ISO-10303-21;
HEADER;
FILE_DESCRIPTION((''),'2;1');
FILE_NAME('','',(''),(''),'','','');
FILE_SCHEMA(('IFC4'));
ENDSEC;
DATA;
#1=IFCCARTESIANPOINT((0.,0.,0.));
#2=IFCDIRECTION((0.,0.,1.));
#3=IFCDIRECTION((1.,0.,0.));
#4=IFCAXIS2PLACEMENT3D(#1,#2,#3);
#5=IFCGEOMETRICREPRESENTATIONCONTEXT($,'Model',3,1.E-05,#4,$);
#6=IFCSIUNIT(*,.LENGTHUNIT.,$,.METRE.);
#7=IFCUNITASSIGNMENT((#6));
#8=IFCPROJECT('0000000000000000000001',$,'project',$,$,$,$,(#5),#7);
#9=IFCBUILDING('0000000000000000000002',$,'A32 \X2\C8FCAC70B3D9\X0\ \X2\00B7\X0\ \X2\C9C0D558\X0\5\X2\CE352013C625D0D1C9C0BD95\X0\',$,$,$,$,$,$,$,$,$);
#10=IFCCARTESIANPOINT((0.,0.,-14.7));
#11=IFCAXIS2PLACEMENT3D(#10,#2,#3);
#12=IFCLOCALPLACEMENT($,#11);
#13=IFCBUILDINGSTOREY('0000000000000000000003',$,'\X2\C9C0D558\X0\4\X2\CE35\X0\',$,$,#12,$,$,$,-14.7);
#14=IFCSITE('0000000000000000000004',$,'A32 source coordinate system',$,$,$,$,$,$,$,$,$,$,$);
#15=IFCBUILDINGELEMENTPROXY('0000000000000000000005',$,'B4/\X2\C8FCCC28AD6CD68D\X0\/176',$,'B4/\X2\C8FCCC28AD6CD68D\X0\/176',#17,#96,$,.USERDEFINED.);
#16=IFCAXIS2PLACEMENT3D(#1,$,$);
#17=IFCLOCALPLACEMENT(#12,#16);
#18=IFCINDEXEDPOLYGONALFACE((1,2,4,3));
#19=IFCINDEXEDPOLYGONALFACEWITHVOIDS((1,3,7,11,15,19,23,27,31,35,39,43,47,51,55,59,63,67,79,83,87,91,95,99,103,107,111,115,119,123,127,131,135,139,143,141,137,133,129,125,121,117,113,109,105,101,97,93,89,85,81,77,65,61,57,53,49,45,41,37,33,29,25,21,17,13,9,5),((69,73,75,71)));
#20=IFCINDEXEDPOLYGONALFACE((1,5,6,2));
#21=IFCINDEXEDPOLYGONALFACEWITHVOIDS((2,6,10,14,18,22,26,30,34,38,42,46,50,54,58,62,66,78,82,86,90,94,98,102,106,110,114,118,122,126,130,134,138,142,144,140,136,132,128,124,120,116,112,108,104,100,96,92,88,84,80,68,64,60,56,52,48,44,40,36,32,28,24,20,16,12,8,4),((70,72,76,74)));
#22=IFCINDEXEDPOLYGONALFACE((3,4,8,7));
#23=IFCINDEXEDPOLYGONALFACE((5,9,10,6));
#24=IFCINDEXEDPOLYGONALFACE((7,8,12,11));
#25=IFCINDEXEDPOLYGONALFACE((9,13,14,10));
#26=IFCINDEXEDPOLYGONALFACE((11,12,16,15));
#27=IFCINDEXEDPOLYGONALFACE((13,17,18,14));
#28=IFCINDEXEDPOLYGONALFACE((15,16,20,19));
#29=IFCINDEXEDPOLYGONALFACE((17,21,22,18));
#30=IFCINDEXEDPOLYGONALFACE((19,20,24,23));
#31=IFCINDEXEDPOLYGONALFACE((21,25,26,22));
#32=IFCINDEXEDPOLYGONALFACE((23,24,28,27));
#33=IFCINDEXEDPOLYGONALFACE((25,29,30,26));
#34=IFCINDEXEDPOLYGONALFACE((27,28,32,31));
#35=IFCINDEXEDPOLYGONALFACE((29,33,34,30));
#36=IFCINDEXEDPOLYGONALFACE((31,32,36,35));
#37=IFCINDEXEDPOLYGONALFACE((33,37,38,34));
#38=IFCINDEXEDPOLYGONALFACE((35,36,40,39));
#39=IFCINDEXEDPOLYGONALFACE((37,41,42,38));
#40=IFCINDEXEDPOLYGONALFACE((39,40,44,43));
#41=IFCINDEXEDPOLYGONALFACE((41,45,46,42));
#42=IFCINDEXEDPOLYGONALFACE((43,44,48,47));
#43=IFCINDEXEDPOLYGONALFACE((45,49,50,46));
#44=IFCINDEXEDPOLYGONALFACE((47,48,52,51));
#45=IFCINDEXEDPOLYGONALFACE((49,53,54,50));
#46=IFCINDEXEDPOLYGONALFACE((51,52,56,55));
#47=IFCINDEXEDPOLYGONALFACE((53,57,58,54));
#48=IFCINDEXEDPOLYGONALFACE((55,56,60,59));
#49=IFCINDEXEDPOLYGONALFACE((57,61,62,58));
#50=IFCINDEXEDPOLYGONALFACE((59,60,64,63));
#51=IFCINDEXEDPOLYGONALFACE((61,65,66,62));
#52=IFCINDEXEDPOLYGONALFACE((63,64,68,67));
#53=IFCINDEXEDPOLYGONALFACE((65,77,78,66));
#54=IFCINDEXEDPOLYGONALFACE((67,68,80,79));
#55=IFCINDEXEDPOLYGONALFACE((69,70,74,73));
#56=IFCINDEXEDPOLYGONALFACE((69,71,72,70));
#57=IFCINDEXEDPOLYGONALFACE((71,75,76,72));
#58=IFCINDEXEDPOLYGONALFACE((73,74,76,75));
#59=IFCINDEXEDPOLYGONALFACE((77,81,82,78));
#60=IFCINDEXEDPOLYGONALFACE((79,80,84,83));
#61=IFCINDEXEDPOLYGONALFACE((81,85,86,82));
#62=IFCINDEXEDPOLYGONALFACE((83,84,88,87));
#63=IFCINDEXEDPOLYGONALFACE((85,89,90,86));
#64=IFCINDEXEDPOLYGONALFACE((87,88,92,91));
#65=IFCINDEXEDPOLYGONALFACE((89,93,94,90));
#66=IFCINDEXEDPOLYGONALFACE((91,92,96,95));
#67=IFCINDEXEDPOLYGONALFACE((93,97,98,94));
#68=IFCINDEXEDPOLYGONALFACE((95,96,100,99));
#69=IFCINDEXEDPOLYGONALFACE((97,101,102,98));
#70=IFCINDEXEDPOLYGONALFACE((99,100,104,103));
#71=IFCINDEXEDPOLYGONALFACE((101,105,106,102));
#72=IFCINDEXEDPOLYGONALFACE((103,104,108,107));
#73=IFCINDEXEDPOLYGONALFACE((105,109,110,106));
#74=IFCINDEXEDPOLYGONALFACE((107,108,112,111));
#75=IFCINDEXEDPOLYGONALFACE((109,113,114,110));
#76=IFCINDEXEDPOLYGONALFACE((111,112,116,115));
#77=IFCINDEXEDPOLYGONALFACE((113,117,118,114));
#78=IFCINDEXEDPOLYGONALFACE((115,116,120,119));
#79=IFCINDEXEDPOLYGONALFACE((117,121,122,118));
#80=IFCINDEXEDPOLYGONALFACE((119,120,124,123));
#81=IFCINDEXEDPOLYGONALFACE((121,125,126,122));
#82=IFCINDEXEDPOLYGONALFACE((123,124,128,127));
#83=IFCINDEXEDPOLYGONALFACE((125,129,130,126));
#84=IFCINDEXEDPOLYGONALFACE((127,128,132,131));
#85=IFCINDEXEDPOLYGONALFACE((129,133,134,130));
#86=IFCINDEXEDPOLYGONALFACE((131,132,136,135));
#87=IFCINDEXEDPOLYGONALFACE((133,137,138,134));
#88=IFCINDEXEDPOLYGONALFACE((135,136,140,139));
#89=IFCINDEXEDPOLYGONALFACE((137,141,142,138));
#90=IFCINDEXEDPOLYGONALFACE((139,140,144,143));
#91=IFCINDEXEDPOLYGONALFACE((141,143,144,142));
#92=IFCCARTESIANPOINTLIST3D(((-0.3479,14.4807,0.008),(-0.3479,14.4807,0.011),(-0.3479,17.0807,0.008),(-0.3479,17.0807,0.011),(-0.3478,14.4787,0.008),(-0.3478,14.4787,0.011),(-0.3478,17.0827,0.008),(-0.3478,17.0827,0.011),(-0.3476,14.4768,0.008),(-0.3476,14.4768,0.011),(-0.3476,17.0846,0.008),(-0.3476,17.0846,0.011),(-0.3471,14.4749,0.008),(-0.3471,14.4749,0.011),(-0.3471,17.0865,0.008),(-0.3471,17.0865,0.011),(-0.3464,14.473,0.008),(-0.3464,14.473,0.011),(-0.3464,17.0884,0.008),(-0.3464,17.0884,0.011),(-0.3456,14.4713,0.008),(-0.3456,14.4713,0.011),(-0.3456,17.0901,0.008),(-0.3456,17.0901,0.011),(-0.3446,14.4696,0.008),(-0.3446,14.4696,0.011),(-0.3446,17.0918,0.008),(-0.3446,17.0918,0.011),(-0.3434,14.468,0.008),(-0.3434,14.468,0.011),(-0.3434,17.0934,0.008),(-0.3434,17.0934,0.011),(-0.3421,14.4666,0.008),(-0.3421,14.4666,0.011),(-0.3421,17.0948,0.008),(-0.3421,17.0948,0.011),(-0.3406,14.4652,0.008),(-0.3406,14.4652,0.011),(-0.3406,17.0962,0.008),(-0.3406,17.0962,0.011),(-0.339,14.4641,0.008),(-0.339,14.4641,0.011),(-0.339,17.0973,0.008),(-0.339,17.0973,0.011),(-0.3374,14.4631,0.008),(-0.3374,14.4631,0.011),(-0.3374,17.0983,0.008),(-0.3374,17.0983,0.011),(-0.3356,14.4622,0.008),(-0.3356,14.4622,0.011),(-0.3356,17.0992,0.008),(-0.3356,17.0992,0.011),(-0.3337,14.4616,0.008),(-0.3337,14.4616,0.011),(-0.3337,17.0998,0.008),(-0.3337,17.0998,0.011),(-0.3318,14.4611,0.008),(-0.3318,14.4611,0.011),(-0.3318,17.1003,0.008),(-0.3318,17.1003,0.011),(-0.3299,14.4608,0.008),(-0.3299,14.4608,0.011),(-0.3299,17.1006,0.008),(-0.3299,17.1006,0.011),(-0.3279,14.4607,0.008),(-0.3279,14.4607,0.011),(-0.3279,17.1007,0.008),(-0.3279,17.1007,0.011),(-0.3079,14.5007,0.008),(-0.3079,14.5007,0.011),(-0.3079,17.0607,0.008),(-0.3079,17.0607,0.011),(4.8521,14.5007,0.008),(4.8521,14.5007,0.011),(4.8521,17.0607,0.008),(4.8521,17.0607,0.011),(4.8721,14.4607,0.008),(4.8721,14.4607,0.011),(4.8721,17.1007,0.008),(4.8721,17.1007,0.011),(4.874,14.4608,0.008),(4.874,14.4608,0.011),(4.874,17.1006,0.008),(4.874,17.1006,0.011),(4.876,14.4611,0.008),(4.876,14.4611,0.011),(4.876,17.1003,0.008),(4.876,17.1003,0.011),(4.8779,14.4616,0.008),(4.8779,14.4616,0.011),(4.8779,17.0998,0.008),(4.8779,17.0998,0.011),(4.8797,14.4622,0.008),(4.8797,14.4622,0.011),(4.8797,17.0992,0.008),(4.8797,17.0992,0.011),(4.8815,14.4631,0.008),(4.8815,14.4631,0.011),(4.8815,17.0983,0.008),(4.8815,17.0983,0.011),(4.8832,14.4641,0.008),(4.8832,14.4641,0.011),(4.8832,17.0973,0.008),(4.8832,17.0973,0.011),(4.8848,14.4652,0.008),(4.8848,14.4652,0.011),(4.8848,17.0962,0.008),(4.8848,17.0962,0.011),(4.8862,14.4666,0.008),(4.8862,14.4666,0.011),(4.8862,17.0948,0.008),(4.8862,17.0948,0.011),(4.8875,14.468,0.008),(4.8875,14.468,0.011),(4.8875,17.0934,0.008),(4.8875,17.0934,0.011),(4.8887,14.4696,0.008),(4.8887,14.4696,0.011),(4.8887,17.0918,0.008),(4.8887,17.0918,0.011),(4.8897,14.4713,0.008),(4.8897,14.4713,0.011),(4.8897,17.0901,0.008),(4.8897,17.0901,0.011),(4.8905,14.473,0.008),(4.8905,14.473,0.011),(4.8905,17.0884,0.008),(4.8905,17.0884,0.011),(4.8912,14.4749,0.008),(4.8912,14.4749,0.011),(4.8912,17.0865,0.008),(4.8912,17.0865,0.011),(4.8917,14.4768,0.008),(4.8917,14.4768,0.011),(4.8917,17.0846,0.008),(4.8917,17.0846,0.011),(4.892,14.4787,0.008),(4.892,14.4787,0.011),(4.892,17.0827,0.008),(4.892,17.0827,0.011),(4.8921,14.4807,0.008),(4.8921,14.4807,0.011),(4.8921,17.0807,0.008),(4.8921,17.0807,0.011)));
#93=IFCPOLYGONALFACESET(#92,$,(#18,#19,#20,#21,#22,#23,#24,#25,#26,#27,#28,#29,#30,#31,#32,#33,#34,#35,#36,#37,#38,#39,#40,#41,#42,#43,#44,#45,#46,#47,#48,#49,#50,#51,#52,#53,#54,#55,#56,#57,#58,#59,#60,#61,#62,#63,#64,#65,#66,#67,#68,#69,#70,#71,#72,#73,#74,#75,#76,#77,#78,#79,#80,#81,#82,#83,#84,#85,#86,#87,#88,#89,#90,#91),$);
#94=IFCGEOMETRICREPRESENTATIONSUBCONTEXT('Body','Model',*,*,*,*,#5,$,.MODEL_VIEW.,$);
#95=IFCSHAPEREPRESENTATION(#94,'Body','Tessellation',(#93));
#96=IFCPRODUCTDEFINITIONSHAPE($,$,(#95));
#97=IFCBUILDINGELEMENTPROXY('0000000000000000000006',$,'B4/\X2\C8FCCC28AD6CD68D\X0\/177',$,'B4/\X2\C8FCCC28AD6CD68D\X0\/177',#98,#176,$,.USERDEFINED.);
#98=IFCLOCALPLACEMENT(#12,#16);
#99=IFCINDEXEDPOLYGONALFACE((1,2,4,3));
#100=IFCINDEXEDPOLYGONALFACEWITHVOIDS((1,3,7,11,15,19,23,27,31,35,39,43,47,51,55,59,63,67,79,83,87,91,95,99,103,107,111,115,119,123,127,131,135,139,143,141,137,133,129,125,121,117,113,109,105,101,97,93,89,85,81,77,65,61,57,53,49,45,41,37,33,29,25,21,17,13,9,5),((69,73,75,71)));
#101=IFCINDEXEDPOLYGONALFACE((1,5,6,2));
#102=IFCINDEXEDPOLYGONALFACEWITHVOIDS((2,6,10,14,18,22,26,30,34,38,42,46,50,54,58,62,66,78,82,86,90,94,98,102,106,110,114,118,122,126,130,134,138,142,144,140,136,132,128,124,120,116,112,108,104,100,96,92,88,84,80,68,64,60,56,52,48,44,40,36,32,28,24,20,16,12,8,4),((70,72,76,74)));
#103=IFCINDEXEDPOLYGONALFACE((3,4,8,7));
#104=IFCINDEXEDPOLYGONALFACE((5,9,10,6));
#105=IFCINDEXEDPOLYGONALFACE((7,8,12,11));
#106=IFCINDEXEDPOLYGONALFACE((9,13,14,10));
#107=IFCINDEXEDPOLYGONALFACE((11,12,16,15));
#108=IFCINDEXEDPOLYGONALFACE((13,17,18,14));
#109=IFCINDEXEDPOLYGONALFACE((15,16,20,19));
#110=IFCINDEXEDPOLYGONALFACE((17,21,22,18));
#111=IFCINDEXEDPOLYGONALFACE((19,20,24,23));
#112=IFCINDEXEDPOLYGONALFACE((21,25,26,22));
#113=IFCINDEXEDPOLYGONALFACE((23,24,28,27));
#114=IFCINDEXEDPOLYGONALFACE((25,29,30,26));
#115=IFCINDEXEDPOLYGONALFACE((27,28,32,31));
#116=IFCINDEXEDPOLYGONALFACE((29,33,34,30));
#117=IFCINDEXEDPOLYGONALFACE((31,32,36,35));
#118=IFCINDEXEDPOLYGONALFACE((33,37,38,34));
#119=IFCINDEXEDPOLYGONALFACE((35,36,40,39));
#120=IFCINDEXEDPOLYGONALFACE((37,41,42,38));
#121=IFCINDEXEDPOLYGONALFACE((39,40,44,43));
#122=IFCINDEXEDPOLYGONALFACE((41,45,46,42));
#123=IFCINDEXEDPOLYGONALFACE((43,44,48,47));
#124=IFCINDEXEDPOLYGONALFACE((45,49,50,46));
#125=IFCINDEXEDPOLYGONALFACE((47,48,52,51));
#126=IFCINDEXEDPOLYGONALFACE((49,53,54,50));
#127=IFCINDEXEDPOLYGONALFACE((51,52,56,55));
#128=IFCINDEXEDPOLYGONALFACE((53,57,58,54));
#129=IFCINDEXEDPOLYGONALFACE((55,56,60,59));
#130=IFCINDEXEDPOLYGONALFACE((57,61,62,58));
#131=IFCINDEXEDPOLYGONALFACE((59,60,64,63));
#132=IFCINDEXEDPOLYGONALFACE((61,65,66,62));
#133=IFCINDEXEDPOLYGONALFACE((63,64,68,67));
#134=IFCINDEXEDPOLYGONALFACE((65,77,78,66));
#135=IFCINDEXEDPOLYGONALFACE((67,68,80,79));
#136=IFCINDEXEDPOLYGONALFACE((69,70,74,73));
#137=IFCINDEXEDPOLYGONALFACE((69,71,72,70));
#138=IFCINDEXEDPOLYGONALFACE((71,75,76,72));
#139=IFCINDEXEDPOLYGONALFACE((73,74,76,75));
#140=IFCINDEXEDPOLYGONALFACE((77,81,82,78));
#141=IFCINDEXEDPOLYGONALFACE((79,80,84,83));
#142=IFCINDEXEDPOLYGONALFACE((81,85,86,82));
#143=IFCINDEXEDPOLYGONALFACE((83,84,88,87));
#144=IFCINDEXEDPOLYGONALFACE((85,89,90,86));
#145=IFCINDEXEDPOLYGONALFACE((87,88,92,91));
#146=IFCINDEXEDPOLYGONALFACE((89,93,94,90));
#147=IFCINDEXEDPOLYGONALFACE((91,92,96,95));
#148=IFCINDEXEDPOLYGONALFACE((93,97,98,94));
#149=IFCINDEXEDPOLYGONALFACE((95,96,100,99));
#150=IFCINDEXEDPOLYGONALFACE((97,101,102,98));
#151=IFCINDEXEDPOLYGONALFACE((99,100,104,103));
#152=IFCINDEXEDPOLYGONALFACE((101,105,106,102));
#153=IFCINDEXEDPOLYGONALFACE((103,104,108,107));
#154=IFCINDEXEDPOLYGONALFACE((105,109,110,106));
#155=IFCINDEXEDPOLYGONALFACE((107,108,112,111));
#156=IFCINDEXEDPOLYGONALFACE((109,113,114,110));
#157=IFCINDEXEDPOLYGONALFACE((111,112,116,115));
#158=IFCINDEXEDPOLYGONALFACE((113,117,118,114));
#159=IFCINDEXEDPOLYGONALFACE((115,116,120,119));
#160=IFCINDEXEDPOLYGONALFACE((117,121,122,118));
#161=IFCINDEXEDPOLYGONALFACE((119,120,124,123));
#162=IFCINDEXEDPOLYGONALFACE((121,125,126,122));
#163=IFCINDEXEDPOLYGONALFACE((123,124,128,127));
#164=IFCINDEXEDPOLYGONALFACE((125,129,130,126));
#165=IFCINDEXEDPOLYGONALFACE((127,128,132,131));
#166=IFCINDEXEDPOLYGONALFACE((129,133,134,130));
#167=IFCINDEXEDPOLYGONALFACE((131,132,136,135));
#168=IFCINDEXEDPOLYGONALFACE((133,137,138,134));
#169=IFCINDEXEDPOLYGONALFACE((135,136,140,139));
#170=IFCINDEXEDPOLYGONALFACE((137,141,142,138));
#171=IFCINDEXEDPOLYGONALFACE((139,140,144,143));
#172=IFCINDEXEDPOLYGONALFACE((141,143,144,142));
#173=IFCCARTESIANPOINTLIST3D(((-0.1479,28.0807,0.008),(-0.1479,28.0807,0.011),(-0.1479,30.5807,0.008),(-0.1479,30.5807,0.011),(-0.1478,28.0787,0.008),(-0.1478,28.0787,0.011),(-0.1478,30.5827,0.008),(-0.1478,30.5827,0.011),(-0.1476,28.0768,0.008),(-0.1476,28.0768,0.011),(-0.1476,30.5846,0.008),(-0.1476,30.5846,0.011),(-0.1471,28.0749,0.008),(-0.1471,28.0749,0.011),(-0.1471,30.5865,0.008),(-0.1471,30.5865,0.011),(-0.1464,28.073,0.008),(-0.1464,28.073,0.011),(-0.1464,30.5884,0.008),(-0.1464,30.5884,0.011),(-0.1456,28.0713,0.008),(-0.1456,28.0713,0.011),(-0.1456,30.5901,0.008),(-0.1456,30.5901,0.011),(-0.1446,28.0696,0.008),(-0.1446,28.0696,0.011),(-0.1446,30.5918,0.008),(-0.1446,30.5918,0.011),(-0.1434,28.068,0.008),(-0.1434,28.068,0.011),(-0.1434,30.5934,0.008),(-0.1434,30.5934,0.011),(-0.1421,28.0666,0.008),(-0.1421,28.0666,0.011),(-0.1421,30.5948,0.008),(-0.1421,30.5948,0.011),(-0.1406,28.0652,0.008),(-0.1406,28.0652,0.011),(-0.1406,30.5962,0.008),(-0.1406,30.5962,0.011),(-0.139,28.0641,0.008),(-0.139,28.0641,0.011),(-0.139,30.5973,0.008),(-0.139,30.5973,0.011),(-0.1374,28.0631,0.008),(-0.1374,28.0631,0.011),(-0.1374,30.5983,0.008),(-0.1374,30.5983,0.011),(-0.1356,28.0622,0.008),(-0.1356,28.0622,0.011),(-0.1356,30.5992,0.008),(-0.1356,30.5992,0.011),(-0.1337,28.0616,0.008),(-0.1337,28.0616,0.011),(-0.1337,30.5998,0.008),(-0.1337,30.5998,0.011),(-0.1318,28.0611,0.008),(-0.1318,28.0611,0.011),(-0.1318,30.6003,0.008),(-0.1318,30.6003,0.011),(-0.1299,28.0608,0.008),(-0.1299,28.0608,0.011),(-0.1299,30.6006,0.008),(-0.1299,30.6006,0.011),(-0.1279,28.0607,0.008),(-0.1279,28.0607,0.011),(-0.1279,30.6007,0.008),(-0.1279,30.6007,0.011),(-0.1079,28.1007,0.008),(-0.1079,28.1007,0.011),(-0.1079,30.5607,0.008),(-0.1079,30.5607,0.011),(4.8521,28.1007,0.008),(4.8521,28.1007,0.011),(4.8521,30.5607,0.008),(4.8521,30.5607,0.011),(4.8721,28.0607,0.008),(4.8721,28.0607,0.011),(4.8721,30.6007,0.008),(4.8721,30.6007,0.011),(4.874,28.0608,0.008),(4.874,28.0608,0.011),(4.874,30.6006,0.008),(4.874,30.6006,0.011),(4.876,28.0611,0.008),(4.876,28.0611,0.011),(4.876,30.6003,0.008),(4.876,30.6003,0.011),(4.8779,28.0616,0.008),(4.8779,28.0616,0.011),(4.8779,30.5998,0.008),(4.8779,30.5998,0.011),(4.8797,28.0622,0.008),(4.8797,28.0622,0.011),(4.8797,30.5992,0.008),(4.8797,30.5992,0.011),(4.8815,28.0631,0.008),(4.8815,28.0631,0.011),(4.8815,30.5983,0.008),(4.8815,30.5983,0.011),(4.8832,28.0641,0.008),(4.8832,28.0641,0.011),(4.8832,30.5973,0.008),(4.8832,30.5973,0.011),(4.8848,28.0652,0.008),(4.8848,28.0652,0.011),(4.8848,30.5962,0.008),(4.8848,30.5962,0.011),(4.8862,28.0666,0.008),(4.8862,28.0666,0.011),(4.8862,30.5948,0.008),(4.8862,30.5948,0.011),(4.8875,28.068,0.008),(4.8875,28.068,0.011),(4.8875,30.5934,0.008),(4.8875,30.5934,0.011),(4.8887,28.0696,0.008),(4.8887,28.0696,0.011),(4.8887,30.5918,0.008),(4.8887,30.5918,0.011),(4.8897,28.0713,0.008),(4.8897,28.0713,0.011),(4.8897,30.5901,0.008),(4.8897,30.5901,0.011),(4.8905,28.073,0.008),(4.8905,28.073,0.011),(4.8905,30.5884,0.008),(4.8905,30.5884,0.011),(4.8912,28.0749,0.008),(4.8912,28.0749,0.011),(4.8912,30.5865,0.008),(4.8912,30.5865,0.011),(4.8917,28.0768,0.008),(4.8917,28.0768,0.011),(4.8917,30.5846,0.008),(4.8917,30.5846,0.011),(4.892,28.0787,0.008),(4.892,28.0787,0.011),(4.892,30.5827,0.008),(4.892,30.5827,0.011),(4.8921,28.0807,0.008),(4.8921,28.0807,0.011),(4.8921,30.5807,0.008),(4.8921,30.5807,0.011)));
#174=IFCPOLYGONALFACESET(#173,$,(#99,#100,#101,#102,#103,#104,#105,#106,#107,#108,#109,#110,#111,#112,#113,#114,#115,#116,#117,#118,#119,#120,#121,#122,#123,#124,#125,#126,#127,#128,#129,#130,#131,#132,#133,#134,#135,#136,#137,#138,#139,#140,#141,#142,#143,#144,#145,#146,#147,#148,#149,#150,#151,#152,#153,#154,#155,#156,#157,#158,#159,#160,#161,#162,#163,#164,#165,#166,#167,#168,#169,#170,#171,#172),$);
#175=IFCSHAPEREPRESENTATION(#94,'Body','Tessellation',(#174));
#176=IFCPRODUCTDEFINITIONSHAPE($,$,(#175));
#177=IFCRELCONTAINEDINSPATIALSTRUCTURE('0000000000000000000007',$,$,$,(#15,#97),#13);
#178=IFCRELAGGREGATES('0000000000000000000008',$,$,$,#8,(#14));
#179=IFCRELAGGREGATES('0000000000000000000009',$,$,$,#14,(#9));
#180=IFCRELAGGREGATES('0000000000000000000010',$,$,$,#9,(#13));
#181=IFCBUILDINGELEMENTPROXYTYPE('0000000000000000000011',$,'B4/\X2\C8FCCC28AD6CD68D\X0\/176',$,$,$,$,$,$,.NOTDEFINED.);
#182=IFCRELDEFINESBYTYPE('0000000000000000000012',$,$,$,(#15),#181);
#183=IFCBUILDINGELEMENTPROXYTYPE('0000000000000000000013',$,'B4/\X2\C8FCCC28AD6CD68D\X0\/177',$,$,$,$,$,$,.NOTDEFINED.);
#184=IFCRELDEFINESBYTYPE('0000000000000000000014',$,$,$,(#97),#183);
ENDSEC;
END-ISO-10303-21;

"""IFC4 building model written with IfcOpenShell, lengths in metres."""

from ifc_helpers import new_model, si_unit, frame, origin, origin_with_axes, place, context, subcontext, project, spatial, polyline, outline, extrude, source, transform, mapped, type_object, type_shapes, element, save


model = new_model("IFC4")

# Units and contexts
model_context = context("Model", 3, precision=1e-05, world=origin_with_axes())
body_context = subcontext(model_context, "Body", "Model", "MODEL_VIEW")
ifc_project = project(units=[si_unit("LENGTHUNIT", "METRE")], contexts=[model_context])

# Site, building, storey
site = spatial("IfcSite", under=ifc_project, Name="A32 source coordinate system")
building = spatial("IfcBuilding", under=site, Name="A32 주거동 · 지하5층–옥탑지붕")
storey_placement = place(None, frame((0.0, 0.0, -14.7), z_axis=(0.0, 0.0, 1.0), x_axis=(1.0, 0.0, 0.0)))
storey = spatial("IfcBuildingStorey", under=building, at=storey_placement, Name="지하4층", Elevation=-14.7)

# Building element proxies
building_element_proxy_type_1 = type_object("IfcBuildingElementProxyType", Name="B4/주차구획/176", PredefinedType="NOTDEFINED")
shared_shape_1 = source(origin(), body_context, "Body", "SweptSolid", [
    extrude(outline(polyline([(-0.3279, 14.4607), (-0.3299, 14.4608), (-0.3318, 14.4611), (-0.3337, 14.4616), (-0.3356, 14.4622), (-0.3374, 14.4631), (-0.339, 14.4641), (-0.3406, 14.4652), (-0.3421, 14.4666), (-0.3434, 14.468), (-0.3446, 14.4696), (-0.3456, 14.4713), (-0.3464, 14.473), (-0.3471, 14.4749), (-0.3476, 14.4768), (-0.3478, 14.4787), (-0.3479, 14.4807), (-0.3479, 17.0807), (-0.3478, 17.0827), (-0.3476, 17.0846), (-0.3471, 17.0865), (-0.3464, 17.0884), (-0.3456, 17.0901), (-0.3446, 17.0918), (-0.3434, 17.0934), (-0.3421, 17.0948), (-0.3406, 17.0962), (-0.339, 17.0973), (-0.3374, 17.0983), (-0.3356, 17.0992), (-0.3337, 17.0998), (-0.3318, 17.1003), (-0.3299, 17.1006), (-0.3279, 17.1007), (4.8721, 17.1007), (4.874, 17.1006), (4.876, 17.1003), (4.8779, 17.0998), (4.8797, 17.0992), (4.8815, 17.0983), (4.8832, 17.0973), (4.8848, 17.0962), (4.8862, 17.0948), (4.8875, 17.0934), (4.8887, 17.0918), (4.8897, 17.0901), (4.8905, 17.0884), (4.8912, 17.0865), (4.8917, 17.0846), (4.892, 17.0827), (4.8921, 17.0807), (4.8921, 14.4807), (4.892, 14.4787), (4.8917, 14.4768), (4.8912, 14.4749), (4.8905, 14.473), (4.8897, 14.4713), (4.8887, 14.4696), (4.8875, 14.468), (4.8862, 14.4666), (4.8848, 14.4652), (4.8832, 14.4641), (4.8815, 14.4631), (4.8797, 14.4622), (4.8779, 14.4616), (4.876, 14.4611), (4.874, 14.4608), (4.8721, 14.4607), (-0.3279, 14.4607)]), holes=[polyline([(-0.3079, 14.5007), (4.8521, 14.5007), (4.8521, 17.0607), (-0.3079, 17.0607), (-0.3079, 14.5007)])]), frame((0.0, 0.0, 0.008)), (0.0, 0.0, 1.0), 0.003),
])
type_shapes(building_element_proxy_type_1, [shared_shape_1])
proxy_1_placement = place(storey_placement, origin_with_axes())
element("IfcBuildingElementProxy", 1, at=proxy_1_placement, inside=storey, type_object=building_element_proxy_type_1, Name="B4/주차구획/176", ObjectType="B4/주차구획/176", PredefinedType="USERDEFINED", context=body_context, shape_type="MappedRepresentation", body=[
    mapped(shared_shape_1, transform((0.0, 0.0, 0.0), scale=1.0)),
])
building_element_proxy_type_2 = type_object("IfcBuildingElementProxyType", Name="B4/주차구획/177", PredefinedType="NOTDEFINED")
shared_shape_2 = source(origin(), body_context, "Body", "SweptSolid", [
    extrude(outline(polyline([(-0.1279, 28.0607), (-0.1299, 28.0608), (-0.1318, 28.0611), (-0.1337, 28.0616), (-0.1356, 28.0622), (-0.1374, 28.0631), (-0.139, 28.0641), (-0.1406, 28.0652), (-0.1421, 28.0666), (-0.1434, 28.068), (-0.1446, 28.0696), (-0.1456, 28.0713), (-0.1464, 28.073), (-0.1471, 28.0749), (-0.1476, 28.0768), (-0.1478, 28.0787), (-0.1479, 28.0807), (-0.1479, 30.5807), (-0.1478, 30.5827), (-0.1476, 30.5846), (-0.1471, 30.5865), (-0.1464, 30.5884), (-0.1456, 30.5901), (-0.1446, 30.5918), (-0.1434, 30.5934), (-0.1421, 30.5948), (-0.1406, 30.5962), (-0.139, 30.5973), (-0.1374, 30.5983), (-0.1356, 30.5992), (-0.1337, 30.5998), (-0.1318, 30.6003), (-0.1299, 30.6006), (-0.1279, 30.6007), (4.8721, 30.6007), (4.874, 30.6006), (4.876, 30.6003), (4.8779, 30.5998), (4.8797, 30.5992), (4.8815, 30.5983), (4.8832, 30.5973), (4.8848, 30.5962), (4.8862, 30.5948), (4.8875, 30.5934), (4.8887, 30.5918), (4.8897, 30.5901), (4.8905, 30.5884), (4.8912, 30.5865), (4.8917, 30.5846), (4.892, 30.5827), (4.8921, 30.5807), (4.8921, 28.0807), (4.892, 28.0787), (4.8917, 28.0768), (4.8912, 28.0749), (4.8905, 28.073), (4.8897, 28.0713), (4.8887, 28.0696), (4.8875, 28.068), (4.8862, 28.0666), (4.8848, 28.0652), (4.8832, 28.0641), (4.8815, 28.0631), (4.8797, 28.0622), (4.8779, 28.0616), (4.876, 28.0611), (4.874, 28.0608), (4.8721, 28.0607), (-0.1279, 28.0607)]), holes=[polyline([(-0.1079, 28.1007), (4.8521, 28.1007), (4.8521, 30.5607), (-0.1079, 30.5607), (-0.1079, 28.1007)])]), frame((0.0, 0.0, 0.008)), (0.0, 0.0, 1.0), 0.003),
])
type_shapes(building_element_proxy_type_2, [shared_shape_2])
proxy_2_placement = place(storey_placement, origin_with_axes())
element("IfcBuildingElementProxy", 2, at=proxy_2_placement, inside=storey, type_object=building_element_proxy_type_2, Name="B4/주차구획/177", ObjectType="B4/주차구획/177", PredefinedType="USERDEFINED", context=body_context, shape_type="MappedRepresentation", body=[
    mapped(shared_shape_2, transform((0.0, 0.0, 0.0), scale=1.0)),
])

save(model, "model.ifc")
